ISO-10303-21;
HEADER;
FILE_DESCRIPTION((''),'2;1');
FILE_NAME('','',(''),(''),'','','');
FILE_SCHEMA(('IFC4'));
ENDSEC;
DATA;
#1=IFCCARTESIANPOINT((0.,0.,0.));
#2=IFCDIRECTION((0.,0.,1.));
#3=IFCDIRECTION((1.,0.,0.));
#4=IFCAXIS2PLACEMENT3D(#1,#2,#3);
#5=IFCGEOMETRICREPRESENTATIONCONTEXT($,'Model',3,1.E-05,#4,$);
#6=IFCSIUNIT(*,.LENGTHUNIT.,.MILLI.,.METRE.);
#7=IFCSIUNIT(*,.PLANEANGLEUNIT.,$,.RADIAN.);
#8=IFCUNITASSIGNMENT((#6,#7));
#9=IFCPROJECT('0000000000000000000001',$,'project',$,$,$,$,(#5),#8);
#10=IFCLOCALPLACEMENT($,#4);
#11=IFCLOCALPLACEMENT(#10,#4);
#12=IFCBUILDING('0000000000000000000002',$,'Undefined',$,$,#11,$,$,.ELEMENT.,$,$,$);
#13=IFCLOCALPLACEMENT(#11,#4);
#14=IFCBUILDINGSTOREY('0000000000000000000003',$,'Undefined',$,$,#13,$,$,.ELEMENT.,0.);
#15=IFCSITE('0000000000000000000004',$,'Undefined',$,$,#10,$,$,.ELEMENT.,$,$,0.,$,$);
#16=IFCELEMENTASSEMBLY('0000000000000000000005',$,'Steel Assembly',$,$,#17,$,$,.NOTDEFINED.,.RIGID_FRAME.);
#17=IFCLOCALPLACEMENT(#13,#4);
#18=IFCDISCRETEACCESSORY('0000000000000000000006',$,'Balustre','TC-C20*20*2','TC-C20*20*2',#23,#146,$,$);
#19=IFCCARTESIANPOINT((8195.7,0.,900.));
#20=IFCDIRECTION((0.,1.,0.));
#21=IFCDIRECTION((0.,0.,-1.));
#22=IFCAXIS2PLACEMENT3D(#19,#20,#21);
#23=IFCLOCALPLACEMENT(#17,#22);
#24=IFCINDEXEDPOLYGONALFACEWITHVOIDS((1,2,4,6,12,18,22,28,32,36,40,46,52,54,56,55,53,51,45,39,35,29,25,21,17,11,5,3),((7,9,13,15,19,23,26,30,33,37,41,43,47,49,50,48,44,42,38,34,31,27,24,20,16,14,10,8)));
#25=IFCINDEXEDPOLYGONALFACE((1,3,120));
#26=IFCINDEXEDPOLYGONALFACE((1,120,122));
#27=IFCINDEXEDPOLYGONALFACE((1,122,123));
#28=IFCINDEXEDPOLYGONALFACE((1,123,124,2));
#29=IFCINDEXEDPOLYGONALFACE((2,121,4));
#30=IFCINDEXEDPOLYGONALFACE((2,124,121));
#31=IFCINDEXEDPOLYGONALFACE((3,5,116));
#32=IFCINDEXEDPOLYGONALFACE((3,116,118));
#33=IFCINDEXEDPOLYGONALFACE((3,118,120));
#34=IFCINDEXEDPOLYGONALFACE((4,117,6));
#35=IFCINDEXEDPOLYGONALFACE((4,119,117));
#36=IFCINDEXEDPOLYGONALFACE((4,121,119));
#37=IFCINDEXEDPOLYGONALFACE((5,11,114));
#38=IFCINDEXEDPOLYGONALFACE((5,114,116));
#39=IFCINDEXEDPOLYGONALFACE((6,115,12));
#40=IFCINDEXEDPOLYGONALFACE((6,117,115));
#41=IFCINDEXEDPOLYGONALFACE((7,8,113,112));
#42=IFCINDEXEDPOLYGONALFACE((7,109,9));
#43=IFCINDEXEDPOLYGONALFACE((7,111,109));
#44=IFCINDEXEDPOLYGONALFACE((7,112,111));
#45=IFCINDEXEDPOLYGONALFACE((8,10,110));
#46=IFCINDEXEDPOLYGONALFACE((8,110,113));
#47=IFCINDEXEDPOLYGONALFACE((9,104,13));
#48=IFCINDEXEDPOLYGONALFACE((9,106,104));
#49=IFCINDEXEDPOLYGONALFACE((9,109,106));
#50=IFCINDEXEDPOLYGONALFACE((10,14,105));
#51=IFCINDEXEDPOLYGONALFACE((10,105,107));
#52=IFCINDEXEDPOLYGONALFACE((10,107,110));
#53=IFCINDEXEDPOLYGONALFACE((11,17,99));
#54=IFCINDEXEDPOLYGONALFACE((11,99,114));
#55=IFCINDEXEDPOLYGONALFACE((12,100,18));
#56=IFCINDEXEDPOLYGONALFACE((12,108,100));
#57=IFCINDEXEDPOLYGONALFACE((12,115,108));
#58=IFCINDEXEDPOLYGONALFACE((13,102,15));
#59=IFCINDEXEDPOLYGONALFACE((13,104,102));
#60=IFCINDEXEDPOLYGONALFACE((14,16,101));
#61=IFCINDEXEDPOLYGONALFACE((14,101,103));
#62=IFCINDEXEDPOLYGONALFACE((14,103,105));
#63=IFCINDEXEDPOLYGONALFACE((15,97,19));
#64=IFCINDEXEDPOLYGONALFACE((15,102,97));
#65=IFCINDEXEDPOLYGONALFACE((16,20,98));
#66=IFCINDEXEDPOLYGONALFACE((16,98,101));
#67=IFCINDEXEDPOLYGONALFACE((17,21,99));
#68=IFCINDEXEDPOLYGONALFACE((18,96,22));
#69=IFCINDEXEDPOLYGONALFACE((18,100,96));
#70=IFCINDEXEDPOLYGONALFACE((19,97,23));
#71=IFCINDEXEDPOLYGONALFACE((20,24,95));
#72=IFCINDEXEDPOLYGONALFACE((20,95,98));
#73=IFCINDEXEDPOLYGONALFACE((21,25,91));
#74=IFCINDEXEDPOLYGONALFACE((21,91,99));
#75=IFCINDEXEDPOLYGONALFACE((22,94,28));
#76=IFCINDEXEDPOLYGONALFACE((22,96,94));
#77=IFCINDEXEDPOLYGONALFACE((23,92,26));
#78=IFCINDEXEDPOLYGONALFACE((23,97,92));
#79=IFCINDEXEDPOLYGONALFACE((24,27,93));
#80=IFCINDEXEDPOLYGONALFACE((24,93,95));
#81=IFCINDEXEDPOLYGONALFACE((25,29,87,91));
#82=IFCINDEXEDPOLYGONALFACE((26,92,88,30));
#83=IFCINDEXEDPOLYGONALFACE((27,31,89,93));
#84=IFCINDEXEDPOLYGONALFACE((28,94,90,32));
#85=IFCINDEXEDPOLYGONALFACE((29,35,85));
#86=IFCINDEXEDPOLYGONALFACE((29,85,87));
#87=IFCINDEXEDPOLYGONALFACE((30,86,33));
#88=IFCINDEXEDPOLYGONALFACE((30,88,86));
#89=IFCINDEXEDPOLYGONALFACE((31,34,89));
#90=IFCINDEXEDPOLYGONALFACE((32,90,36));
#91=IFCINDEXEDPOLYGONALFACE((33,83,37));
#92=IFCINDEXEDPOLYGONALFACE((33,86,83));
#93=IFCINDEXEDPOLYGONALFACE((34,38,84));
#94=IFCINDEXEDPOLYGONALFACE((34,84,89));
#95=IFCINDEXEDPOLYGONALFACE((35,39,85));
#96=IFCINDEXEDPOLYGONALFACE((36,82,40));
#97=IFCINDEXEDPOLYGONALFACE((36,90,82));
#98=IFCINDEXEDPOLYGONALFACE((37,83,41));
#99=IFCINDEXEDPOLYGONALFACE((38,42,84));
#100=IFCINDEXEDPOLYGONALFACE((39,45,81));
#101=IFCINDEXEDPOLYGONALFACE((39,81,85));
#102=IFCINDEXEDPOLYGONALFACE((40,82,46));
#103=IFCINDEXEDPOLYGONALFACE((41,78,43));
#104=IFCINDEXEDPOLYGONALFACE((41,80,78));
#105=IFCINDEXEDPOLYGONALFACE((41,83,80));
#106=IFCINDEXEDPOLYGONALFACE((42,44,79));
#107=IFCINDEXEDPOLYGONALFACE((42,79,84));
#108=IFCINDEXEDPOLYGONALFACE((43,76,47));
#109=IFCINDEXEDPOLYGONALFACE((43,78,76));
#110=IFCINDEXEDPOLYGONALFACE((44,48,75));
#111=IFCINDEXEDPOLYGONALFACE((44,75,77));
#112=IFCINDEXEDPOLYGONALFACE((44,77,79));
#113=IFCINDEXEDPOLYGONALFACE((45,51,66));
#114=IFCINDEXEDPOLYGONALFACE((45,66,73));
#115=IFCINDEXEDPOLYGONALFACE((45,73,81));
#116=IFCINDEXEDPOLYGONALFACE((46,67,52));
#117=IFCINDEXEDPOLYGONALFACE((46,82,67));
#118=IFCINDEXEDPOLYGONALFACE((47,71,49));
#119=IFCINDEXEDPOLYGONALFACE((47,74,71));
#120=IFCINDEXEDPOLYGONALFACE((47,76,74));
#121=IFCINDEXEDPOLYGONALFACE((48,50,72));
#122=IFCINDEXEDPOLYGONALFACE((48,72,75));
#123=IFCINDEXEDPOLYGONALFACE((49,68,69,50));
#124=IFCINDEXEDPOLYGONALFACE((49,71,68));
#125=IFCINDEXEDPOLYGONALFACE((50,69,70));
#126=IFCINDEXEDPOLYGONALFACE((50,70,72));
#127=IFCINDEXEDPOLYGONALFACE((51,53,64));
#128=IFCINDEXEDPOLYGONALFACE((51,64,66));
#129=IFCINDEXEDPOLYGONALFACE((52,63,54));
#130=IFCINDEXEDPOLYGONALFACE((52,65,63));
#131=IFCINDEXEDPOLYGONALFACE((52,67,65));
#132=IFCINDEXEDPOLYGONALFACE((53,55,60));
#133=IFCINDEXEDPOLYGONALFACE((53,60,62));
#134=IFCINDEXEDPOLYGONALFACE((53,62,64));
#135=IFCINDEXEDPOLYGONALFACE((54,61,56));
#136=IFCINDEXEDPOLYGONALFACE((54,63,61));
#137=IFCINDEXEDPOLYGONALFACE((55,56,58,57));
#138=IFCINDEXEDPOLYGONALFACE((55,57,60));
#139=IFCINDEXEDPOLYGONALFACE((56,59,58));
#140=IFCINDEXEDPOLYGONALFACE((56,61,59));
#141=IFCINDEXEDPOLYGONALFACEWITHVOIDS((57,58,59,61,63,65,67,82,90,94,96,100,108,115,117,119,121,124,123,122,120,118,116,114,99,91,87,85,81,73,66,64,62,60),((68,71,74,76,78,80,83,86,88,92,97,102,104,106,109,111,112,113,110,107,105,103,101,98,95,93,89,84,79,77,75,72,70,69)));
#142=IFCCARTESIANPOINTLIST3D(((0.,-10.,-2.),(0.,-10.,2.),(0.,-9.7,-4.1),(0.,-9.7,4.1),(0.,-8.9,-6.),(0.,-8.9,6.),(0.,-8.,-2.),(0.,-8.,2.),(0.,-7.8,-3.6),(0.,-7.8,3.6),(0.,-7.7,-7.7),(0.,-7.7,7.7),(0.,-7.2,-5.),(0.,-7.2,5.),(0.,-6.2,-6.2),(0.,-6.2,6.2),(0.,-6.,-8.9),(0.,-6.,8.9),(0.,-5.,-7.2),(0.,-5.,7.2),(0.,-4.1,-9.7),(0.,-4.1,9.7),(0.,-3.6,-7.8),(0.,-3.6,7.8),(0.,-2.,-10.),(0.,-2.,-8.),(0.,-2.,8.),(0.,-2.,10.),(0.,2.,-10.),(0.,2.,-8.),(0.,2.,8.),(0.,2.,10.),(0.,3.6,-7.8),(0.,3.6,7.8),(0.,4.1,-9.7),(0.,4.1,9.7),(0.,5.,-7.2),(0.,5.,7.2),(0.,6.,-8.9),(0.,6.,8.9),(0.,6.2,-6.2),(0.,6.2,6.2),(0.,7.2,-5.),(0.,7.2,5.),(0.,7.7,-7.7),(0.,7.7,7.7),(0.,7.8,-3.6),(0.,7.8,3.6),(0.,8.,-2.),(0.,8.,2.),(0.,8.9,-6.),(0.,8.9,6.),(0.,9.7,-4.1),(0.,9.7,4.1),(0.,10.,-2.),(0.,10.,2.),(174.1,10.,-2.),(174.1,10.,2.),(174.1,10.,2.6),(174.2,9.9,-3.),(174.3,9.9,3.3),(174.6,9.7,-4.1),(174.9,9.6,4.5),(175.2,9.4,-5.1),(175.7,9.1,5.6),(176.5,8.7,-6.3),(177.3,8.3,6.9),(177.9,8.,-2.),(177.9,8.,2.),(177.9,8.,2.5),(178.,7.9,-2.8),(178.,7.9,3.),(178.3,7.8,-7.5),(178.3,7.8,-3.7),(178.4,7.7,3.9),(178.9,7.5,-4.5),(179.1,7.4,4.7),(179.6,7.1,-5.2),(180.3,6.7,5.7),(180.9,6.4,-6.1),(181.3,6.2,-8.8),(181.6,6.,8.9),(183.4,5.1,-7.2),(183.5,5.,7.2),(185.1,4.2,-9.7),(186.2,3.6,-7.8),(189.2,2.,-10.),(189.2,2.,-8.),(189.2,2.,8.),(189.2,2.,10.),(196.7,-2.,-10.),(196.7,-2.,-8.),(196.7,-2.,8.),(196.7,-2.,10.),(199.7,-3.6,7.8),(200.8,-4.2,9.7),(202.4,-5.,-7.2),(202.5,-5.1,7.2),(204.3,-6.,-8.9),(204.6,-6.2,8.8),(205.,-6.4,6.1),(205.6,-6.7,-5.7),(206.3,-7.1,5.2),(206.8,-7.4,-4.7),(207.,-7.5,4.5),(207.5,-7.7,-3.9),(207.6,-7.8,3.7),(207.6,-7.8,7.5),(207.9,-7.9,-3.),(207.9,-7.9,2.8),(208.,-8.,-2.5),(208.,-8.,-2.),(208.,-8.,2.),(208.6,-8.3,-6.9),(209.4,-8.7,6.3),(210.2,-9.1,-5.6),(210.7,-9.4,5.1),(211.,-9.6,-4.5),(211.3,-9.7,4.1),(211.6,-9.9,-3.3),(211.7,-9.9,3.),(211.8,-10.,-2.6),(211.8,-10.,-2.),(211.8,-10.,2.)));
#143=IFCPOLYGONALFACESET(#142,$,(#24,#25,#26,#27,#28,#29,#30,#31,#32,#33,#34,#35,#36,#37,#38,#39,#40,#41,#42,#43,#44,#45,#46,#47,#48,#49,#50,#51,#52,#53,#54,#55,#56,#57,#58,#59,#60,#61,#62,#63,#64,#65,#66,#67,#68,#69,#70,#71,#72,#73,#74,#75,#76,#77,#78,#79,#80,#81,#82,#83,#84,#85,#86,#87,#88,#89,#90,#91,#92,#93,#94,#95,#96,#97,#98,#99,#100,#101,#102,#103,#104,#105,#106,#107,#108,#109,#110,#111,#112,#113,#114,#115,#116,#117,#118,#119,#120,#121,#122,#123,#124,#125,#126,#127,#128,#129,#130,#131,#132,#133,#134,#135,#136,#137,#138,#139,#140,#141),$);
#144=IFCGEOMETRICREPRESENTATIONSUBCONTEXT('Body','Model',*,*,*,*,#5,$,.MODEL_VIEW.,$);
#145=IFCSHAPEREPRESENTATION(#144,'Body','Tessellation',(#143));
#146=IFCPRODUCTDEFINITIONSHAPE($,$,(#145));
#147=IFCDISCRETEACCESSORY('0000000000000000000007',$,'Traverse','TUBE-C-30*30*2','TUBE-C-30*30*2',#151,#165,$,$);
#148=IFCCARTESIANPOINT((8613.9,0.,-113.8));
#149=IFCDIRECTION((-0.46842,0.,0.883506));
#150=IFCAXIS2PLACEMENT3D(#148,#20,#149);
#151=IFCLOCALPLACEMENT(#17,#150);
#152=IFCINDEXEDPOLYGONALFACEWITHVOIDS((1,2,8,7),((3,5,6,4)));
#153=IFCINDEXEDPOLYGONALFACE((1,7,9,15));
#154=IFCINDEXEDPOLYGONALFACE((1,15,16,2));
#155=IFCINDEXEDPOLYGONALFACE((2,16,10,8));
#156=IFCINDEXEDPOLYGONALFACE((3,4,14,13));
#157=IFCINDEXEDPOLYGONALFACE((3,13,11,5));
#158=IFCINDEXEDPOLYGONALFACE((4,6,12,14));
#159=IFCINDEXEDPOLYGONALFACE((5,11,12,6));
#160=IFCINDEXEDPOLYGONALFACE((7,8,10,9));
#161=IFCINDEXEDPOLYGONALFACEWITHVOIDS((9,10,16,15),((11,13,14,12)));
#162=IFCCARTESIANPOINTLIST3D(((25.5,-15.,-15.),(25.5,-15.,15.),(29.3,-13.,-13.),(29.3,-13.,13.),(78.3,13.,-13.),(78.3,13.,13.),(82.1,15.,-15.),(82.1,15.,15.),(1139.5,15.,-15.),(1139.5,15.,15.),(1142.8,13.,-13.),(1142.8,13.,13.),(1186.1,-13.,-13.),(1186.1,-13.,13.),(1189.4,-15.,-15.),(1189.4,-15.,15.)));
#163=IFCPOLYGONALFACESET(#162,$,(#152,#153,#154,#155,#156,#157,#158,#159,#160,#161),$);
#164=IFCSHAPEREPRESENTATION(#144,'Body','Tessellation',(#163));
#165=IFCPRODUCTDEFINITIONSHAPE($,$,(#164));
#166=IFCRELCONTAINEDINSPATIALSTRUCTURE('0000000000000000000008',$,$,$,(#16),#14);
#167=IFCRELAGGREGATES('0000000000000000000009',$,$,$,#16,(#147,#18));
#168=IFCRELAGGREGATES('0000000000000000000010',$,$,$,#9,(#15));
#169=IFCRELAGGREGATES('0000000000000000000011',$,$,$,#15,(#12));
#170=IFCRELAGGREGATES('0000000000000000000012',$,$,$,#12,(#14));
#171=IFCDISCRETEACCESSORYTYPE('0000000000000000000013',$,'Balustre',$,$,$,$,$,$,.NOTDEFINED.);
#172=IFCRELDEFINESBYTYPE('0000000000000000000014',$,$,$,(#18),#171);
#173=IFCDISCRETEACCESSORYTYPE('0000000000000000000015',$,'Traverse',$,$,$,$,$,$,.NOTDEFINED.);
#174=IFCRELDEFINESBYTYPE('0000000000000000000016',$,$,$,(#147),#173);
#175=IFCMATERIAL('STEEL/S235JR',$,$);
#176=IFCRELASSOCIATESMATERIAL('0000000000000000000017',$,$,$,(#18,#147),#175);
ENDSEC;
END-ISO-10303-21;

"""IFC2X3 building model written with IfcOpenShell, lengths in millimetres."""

from ifc_helpers import new_model, si_unit, frame, origin_with_axes, origin_2d_with_axis, place, context, subcontext, project, spatial, hollow_rectangle, extrude, clip, halfspace, material, type_object, element, aggregate, save


model = new_model("IFC2X3")

# Units and contexts
model_context = context("Model", 3, precision=1e-05, world=origin_with_axes())
body_context = subcontext(model_context, "Body", "Model", "MODEL_VIEW")
ifc_project = project(units=[si_unit("LENGTHUNIT", "METRE", prefix="MILLI"), si_unit("PLANEANGLEUNIT", "RADIAN")], contexts=[model_context])

# Site, building, storey
site_placement = place(None, origin_with_axes())
site = spatial("IfcSite", under=ifc_project, at=site_placement, Name="Undefined", CompositionType="ELEMENT", RefElevation=0.0)
building_placement = place(site_placement, origin_with_axes())
building = spatial("IfcBuilding", under=site, at=building_placement, Name="Undefined", CompositionType="ELEMENT")
storey_placement = place(building_placement, origin_with_axes())
storey = spatial("IfcBuildingStorey", under=building, at=storey_placement, Name="Undefined", CompositionType="ELEMENT", Elevation=0.0)

# Shared definitions
ifc_material = material(Name="STEEL/S235JR")

# Shared definitions
discrete_accessory_type_1 = type_object("IfcDiscreteAccessoryType", Name="Balustre")

# Element assembly, discrete accessory
assembly_1_placement = place(storey_placement, origin_with_axes())
assembly_1 = element("IfcElementAssembly", 1, at=assembly_1_placement, inside=storey, Name="Steel Assembly", AssemblyPlace="NOTDEFINED", PredefinedType="RIGID_FRAME")
discrete_accessory_1_placement = place(assembly_1_placement, frame((8195.7, 0.0, 900.0), z_axis=(0.0, 1.0, 0.0), x_axis=(0.0, 0.0, -1.0)))
discrete_accessory_1 = element("IfcDiscreteAccessory", 2, at=discrete_accessory_1_placement, type_object=discrete_accessory_type_1, material=ifc_material, Name="Balustre", Description="TC-C20*20*2", ObjectType="TC-C20*20*2", context=body_context, shape_type="Clipping", body=[
    clip(extrude(hollow_rectangle(XDim=20.0, YDim=20.0, WallThickness=2.0, InnerFilletRadius=6.0, OuterFilletRadius=8.0, at=origin_2d_with_axis()), frame((212.0, 0.0, 0.0), z_axis=(-1.0, 0.0, 0.0), x_axis=(0.0, -1.0, 0.0)), (0.0, 0.0, 1.0), 212.0), halfspace(frame((150.3, 22.6, 0.0), z_axis=(-0.46842, -0.883506, 0.000005), x_axis=(0.0, 0.000005, 1.0)), True)),
])

# Discrete accessory
discrete_accessory_type_2 = type_object("IfcDiscreteAccessoryType", Name="Traverse")
discrete_accessory_2_placement = place(assembly_1_placement, frame((8613.9, 0.0, -113.8), z_axis=(0.0, 1.0, 0.0), x_axis=(-0.46842, 0.0, 0.883506)))
discrete_accessory_2 = element("IfcDiscreteAccessory", 3, at=discrete_accessory_2_placement, type_object=discrete_accessory_type_2, material=ifc_material, Name="Traverse", Description="TUBE-C-30*30*2", ObjectType="TUBE-C-30*30*2", context=body_context, shape_type="Clipping", body=[
    clip(clip(extrude(hollow_rectangle(XDim=30.0, YDim=30.0, WallThickness=2.0, at=origin_2d_with_axis()), frame((1218.2, 0.0, 0.0), z_axis=(-1.0, 0.0, 0.0), x_axis=(0.0, -1.0, 0.0)), (0.0, 0.0, 1.0), 1218.2), halfspace(frame((1139.5, 15.0, 0.0), z_axis=(-0.515548, -0.856861, -0.000003), x_axis=(0.000003, -0.000005, 1.0)), True)), halfspace(frame((82.1, 15.0, 0.0), z_axis=(-0.46842, 0.883506, 0.000005), x_axis=(0.000003, -0.000005, 1.0)), False)),
])
aggregate(assembly_1, [discrete_accessory_2, discrete_accessory_1])

save(model, "model.ifc")
